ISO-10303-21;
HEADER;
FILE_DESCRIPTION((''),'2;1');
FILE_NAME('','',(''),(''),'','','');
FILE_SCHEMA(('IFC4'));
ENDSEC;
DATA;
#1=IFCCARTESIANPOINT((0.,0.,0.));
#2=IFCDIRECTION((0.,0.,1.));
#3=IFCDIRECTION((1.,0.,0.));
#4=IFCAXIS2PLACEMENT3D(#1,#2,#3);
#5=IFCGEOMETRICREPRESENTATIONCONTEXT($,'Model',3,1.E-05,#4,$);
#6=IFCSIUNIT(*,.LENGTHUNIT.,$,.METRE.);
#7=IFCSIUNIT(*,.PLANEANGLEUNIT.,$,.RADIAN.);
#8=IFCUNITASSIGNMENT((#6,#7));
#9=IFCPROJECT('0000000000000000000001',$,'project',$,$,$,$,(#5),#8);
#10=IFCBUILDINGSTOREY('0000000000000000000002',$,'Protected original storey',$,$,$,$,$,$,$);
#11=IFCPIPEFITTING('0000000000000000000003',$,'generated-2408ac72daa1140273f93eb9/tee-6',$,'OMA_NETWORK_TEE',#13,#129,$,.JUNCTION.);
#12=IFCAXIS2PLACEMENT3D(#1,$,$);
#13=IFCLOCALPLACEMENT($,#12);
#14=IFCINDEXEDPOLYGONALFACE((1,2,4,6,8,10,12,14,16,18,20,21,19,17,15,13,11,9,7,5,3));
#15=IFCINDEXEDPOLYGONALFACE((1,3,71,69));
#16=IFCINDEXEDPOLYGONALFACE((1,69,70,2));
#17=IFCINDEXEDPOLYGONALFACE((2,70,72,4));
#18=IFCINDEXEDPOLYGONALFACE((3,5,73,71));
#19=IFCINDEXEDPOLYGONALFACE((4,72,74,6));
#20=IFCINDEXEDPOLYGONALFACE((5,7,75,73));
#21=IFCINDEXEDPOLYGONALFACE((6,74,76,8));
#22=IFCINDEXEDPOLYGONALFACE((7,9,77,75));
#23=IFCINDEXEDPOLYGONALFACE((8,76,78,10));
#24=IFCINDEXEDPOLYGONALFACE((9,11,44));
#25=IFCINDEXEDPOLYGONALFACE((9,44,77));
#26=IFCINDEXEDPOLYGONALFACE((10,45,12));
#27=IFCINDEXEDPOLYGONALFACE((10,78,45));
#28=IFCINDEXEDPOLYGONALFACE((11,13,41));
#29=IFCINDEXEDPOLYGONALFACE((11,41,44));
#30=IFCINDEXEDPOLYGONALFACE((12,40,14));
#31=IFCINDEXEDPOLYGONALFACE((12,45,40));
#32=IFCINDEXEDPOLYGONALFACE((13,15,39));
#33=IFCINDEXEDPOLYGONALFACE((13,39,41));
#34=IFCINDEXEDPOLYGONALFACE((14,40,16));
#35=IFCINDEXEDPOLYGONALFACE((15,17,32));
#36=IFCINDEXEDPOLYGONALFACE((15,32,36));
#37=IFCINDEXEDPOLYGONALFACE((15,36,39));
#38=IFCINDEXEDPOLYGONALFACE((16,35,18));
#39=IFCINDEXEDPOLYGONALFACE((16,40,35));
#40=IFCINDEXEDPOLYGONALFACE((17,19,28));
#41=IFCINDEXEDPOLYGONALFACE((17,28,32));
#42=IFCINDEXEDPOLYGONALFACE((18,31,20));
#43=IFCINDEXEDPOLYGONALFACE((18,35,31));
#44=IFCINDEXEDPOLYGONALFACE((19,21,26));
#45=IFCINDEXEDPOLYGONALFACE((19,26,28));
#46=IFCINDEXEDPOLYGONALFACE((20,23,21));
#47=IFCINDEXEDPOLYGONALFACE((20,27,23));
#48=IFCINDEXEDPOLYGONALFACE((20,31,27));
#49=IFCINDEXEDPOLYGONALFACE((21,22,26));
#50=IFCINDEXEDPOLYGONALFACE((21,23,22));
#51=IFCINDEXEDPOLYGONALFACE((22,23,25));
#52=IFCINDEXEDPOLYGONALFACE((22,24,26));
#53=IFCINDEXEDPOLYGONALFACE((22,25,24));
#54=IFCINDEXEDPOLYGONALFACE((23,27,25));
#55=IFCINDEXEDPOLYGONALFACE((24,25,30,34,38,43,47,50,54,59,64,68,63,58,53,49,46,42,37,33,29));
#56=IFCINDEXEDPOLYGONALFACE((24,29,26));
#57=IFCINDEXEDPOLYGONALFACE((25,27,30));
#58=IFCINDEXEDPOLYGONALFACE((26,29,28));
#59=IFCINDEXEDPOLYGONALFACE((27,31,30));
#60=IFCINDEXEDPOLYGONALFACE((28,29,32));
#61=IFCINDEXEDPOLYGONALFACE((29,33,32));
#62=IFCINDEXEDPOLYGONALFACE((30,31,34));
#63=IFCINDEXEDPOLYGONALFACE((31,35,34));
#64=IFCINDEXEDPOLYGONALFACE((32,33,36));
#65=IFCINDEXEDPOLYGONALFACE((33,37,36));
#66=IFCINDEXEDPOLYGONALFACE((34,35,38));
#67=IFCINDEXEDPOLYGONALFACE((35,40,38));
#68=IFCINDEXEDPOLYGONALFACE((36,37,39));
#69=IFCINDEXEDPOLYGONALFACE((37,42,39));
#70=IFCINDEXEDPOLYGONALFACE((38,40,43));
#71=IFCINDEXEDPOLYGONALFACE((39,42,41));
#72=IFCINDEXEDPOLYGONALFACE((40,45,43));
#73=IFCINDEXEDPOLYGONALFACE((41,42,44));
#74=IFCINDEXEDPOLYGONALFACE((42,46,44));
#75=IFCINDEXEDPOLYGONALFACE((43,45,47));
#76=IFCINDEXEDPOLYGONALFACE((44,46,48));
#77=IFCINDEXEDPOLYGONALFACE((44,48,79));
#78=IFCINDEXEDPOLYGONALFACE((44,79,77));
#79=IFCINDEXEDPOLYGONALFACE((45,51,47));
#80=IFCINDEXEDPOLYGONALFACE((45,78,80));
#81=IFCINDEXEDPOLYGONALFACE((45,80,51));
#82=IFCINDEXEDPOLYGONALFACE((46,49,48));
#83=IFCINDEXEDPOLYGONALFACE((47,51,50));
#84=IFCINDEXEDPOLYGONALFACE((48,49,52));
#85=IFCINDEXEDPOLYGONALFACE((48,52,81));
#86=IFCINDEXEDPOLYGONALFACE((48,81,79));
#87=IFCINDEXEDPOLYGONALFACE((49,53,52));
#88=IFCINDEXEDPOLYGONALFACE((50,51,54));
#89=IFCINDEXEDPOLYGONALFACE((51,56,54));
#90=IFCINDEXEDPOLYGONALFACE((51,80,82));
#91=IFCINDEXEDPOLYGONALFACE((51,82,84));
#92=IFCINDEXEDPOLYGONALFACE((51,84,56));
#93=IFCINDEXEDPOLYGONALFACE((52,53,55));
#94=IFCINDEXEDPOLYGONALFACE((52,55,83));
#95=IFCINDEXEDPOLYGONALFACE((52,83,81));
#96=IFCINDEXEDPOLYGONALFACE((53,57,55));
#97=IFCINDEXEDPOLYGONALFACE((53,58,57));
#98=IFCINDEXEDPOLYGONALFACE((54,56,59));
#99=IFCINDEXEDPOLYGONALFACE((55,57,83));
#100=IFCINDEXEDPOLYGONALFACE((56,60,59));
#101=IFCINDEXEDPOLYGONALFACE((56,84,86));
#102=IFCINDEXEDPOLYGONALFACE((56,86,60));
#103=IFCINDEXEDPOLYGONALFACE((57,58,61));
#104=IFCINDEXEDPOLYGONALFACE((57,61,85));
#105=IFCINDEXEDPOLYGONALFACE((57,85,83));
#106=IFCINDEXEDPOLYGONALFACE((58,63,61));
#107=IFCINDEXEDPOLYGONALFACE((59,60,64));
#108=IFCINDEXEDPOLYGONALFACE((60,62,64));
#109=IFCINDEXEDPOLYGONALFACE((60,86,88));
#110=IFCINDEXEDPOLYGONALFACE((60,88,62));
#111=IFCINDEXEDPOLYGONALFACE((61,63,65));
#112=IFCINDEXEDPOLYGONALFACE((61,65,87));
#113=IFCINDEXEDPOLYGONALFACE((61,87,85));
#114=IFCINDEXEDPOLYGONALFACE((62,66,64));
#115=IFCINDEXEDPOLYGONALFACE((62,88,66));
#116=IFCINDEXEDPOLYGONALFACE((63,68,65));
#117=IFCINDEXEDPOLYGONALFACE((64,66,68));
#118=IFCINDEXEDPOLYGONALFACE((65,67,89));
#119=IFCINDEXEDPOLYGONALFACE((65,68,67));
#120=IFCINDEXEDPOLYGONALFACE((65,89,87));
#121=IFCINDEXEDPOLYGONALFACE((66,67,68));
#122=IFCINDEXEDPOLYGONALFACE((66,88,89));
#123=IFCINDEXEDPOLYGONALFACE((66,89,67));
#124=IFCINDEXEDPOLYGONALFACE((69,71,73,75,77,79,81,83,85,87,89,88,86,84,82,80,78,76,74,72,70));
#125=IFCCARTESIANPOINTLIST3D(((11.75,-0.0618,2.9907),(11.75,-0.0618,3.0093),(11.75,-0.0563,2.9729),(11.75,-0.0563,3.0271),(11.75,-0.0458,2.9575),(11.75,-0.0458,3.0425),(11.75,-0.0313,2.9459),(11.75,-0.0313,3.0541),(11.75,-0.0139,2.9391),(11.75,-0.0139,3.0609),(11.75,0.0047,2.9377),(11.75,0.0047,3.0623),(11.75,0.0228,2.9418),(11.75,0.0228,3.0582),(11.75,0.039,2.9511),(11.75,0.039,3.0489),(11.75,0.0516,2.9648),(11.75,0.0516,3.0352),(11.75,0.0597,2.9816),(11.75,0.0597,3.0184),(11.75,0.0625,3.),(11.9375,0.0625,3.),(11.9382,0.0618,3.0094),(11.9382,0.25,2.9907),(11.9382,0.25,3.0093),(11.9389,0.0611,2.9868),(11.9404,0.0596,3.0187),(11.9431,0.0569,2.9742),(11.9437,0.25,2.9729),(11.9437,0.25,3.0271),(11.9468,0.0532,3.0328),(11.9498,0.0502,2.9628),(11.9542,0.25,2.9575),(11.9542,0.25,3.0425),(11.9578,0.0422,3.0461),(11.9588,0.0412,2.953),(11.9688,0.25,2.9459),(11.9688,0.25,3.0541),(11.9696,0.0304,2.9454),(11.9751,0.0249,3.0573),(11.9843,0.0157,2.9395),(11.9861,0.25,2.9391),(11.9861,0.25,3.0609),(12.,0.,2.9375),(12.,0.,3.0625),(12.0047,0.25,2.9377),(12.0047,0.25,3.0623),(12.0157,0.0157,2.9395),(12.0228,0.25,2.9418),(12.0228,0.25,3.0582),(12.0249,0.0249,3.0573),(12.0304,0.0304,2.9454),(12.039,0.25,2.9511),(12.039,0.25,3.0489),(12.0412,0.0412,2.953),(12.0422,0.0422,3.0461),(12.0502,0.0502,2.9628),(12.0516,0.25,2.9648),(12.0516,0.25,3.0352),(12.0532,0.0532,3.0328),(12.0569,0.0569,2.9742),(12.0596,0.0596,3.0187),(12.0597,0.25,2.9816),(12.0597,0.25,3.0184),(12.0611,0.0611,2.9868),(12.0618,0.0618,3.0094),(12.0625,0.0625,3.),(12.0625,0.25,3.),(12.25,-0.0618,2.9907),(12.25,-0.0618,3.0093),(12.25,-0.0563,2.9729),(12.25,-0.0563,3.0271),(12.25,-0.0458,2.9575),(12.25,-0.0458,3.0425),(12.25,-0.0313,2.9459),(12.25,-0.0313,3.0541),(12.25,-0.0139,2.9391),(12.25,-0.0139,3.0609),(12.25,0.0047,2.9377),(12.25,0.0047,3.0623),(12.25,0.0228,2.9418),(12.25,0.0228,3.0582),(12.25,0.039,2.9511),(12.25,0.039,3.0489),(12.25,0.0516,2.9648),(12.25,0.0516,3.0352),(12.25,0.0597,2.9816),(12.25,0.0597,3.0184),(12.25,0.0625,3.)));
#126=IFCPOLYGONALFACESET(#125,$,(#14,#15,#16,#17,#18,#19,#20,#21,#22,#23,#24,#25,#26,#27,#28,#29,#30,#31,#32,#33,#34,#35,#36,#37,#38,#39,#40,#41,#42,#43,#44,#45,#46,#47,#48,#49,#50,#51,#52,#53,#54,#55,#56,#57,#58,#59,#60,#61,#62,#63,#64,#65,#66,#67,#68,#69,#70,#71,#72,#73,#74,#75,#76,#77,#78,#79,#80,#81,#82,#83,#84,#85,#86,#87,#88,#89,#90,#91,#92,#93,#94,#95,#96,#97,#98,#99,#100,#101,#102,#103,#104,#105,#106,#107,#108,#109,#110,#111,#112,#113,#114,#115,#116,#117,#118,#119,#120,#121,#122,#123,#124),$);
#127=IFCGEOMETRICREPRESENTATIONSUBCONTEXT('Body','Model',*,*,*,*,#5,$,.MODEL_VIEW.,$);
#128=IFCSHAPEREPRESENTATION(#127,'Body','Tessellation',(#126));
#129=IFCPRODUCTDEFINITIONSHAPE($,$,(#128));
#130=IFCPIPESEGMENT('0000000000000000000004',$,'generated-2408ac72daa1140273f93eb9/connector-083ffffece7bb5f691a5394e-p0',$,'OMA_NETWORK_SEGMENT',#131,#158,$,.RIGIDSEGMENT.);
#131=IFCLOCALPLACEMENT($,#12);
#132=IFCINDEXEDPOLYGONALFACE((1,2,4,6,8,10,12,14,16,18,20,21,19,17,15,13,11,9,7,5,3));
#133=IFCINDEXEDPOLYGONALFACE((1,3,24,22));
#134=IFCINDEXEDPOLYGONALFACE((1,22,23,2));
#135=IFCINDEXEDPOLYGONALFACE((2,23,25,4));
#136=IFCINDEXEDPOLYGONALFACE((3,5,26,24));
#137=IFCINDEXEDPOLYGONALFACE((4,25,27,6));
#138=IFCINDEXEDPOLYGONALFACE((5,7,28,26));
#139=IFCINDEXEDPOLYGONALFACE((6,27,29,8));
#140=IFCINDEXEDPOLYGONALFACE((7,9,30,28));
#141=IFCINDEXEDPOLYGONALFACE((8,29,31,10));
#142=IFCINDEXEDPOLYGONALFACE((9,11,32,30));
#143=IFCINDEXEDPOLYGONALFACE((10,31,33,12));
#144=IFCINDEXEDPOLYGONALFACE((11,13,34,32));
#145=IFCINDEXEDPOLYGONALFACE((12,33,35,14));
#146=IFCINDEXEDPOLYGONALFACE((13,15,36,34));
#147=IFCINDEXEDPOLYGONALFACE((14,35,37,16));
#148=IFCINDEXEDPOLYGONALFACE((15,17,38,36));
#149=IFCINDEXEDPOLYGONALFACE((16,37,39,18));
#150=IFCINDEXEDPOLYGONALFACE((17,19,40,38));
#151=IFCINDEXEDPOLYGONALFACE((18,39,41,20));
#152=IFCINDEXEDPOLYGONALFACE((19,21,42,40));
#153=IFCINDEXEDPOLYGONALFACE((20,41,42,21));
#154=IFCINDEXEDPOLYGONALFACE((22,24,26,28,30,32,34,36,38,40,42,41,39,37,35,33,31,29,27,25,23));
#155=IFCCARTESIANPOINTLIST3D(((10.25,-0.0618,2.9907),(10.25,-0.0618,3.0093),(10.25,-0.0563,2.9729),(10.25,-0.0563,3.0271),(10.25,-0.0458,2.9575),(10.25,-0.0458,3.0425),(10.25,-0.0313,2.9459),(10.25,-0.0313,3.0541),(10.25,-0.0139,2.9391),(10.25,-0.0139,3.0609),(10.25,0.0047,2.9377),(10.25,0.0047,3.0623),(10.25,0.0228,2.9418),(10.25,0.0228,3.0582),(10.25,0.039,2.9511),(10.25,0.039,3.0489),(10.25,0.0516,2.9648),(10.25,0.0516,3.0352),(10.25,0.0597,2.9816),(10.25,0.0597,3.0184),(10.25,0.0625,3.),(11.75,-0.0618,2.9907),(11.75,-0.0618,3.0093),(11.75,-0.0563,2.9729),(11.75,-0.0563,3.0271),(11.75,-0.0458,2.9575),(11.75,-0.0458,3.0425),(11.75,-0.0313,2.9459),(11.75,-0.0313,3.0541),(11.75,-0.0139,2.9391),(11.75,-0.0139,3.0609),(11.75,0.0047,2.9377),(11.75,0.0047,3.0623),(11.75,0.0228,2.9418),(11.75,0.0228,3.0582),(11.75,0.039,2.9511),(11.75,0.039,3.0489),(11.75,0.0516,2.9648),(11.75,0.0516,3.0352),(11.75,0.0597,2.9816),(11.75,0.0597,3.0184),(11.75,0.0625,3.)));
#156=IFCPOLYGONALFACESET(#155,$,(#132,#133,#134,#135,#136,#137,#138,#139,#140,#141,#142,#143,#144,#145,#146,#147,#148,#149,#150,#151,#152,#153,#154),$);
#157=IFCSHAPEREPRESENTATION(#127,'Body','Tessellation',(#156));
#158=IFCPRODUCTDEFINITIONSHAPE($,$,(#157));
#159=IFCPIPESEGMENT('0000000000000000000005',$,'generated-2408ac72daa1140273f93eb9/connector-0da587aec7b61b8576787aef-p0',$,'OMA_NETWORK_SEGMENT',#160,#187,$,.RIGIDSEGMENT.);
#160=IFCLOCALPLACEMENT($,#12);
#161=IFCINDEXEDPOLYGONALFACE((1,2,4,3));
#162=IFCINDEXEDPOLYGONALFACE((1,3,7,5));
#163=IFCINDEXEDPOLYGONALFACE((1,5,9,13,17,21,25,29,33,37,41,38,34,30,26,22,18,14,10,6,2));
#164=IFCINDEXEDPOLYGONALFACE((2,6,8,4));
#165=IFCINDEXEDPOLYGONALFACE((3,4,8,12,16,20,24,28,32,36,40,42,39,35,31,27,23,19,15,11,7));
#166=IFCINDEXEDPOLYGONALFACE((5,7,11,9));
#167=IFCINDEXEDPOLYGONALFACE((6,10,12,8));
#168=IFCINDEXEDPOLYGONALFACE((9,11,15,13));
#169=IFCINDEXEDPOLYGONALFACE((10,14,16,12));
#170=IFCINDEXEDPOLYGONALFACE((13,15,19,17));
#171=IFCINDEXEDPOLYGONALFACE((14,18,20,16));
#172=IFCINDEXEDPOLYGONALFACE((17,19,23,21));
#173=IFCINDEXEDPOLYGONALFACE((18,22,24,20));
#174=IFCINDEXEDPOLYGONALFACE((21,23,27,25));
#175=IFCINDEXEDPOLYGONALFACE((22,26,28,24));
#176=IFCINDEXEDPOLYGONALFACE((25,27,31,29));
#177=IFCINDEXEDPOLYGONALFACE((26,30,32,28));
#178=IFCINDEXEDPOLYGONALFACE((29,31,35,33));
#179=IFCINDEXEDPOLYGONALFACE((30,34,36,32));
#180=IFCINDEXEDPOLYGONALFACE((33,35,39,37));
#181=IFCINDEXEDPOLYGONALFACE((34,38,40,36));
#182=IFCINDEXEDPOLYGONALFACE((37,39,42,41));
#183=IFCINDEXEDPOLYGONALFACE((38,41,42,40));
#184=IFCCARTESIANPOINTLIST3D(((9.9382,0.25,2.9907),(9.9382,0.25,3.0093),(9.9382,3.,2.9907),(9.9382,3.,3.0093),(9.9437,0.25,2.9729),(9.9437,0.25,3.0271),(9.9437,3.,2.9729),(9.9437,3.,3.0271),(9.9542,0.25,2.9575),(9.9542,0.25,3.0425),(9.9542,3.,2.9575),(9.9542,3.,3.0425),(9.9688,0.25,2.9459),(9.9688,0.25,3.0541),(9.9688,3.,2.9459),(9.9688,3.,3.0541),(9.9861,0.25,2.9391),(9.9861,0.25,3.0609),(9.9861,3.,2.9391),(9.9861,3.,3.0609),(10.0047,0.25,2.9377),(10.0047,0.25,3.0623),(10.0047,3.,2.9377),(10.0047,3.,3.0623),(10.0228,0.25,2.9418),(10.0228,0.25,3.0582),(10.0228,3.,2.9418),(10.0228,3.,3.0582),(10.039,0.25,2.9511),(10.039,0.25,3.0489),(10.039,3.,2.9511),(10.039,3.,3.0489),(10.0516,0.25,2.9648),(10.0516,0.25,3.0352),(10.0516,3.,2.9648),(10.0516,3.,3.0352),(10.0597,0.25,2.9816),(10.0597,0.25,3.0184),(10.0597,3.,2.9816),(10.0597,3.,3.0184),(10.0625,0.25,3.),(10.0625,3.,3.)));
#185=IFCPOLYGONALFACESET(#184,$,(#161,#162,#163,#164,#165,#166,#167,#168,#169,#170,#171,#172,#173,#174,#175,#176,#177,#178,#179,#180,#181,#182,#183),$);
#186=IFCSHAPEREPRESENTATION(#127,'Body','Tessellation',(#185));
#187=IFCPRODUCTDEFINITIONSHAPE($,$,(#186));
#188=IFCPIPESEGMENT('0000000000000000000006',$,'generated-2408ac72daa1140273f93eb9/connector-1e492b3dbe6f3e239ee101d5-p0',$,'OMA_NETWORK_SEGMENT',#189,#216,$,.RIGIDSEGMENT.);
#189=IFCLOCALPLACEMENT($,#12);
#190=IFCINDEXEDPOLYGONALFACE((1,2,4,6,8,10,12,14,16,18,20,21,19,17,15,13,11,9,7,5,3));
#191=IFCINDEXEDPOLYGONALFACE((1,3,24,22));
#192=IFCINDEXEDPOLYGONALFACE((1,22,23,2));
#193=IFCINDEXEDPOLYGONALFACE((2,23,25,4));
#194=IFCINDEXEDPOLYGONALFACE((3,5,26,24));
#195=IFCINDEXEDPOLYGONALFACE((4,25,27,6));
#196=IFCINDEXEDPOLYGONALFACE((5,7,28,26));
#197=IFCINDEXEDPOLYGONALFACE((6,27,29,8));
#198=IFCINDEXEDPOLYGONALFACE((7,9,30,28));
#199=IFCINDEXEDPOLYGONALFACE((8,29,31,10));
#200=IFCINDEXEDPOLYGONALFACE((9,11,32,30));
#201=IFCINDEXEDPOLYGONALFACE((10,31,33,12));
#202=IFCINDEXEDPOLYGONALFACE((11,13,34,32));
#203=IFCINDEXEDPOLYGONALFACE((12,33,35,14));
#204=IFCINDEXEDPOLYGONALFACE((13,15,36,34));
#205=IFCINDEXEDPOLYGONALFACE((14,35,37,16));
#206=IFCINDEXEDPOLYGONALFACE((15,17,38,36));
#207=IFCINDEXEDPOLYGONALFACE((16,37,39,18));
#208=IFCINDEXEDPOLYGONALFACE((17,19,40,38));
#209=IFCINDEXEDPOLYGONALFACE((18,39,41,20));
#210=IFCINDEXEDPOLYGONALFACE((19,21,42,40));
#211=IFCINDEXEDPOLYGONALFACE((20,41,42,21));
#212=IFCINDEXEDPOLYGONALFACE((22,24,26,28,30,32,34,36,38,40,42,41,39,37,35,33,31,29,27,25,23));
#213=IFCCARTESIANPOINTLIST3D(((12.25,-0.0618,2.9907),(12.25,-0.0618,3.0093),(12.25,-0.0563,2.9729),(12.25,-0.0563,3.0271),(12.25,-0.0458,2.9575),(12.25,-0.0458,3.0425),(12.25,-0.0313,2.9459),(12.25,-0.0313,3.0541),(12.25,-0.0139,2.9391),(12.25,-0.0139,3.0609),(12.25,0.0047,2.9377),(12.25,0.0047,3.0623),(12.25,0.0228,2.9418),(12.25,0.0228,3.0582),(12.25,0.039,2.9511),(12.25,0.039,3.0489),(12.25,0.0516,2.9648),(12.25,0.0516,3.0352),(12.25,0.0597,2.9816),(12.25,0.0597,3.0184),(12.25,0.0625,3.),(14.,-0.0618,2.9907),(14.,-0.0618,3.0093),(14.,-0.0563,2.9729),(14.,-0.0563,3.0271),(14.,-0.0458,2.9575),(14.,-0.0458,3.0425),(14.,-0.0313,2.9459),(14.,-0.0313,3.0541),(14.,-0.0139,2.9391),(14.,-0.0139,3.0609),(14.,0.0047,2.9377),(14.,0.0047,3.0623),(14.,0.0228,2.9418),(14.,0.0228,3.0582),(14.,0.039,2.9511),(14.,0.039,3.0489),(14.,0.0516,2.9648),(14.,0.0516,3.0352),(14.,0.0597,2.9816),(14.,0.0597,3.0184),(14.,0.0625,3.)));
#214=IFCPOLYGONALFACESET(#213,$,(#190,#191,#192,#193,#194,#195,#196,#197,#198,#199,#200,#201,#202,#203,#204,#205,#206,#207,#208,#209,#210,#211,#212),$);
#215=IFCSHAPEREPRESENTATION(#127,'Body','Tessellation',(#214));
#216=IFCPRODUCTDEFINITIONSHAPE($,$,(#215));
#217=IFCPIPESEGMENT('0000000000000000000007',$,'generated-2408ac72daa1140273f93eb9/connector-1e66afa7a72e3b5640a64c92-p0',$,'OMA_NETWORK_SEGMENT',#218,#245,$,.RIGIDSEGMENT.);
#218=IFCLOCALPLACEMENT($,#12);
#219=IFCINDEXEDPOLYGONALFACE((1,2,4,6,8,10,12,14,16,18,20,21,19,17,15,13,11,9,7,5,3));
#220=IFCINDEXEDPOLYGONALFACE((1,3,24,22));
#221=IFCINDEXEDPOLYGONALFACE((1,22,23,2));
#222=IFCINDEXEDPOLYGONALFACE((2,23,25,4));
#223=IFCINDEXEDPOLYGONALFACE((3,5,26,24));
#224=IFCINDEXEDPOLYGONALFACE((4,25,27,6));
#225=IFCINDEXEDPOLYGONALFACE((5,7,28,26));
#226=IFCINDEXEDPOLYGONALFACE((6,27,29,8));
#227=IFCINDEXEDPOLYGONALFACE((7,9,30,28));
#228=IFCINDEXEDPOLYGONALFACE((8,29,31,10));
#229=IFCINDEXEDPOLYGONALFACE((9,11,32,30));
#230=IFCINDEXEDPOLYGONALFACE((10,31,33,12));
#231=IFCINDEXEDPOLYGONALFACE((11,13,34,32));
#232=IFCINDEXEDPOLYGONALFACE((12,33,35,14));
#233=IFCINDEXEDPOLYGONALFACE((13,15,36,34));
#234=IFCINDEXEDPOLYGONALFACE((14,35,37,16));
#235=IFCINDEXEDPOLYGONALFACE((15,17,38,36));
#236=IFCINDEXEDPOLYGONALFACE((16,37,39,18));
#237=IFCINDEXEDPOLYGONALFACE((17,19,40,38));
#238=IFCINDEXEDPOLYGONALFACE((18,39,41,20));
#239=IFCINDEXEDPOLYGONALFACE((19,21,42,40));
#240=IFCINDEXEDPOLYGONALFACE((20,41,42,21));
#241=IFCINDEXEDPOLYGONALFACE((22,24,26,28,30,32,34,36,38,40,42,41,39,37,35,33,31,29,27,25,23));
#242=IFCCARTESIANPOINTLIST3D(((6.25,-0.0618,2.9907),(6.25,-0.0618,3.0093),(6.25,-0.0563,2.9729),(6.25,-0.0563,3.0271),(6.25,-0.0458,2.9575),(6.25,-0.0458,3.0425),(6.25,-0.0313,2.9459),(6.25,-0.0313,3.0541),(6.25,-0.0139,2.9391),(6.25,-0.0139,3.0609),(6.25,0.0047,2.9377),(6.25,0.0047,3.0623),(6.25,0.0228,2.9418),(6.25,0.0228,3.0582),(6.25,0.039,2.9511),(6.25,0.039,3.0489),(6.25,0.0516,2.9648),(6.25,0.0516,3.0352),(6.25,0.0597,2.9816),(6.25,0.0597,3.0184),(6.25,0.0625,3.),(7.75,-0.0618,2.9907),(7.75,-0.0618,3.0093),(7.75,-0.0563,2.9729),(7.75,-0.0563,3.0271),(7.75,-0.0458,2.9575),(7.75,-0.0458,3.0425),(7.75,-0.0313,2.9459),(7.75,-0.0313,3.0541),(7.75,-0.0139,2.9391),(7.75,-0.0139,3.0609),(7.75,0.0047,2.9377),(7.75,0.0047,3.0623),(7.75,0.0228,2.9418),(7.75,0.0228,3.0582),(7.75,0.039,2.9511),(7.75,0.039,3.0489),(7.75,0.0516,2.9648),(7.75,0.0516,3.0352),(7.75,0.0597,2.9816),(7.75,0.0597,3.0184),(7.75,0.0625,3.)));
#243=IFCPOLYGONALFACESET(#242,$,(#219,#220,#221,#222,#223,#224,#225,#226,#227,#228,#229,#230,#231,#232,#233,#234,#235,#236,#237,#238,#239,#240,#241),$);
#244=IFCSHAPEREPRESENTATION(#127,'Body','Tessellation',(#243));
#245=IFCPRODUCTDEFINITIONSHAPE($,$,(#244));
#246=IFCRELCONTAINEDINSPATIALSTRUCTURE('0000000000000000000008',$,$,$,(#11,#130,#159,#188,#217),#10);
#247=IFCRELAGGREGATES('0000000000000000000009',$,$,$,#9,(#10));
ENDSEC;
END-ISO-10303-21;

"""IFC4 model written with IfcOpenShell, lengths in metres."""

from ifc_helpers import new_model, si_unit, frame, origin_with_axes, origin_2d, place, context, subcontext, project, spatial, circle, extrude, boolean, element, save


model = new_model("IFC4")

# Units and contexts
model_context = context("Model", 3, precision=1e-05, world=origin_with_axes())
body_context = subcontext(model_context, "Body", "Model", "MODEL_VIEW")
ifc_project = project(units=[si_unit("LENGTHUNIT", "METRE"), si_unit("PLANEANGLEUNIT", "RADIAN")], contexts=[model_context])

# Storey
storey = spatial("IfcBuildingStorey", under=ifc_project, Name="Protected original storey")

# Pipe fitting
pipe_fitting_1_placement = place(None, origin_with_axes())
element("IfcPipeFitting", 1, at=pipe_fitting_1_placement, inside=storey, Name="generated-2408ac72daa1140273f93eb9/tee-6", ObjectType="OMA_NETWORK_TEE", PredefinedType="JUNCTION", context=body_context, shape_type="CSG", body=[
    boolean("UNION", extrude(circle(Radius=0.0625, at=origin_2d()), frame((11.75, 0.0, 3.0), z_axis=(1.0, 0.0, 0.0), x_axis=(0.0, 1.0, 0.0)), (0.0, 0.0, 1.0), 0.5), extrude(circle(Radius=0.0625, at=origin_2d()), frame((12.0, 0.0, 3.0), z_axis=(0.0, 1.0, 0.0), x_axis=(1.0, 0.0, 0.0)), (0.0, 0.0, 1.0), 0.25)),
])

# Pipe segments
pipe_segment_1_placement = place(None, origin_with_axes())
element("IfcPipeSegment", 2, at=pipe_segment_1_placement, inside=storey, Name="generated-2408ac72daa1140273f93eb9/connector-083ffffece7bb5f691a5394e-p0", ObjectType="OMA_NETWORK_SEGMENT", PredefinedType="RIGIDSEGMENT", context=body_context, shape_type="SweptSolid", body=[
    extrude(circle(Radius=0.0625, at=origin_2d()), frame((10.25, 0.0, 3.0), z_axis=(1.0, 0.0, 0.0), x_axis=(0.0, 1.0, 0.0)), (0.0, 0.0, 1.0), 1.5),
])
pipe_segment_2_placement = place(None, origin_with_axes())
element("IfcPipeSegment", 3, at=pipe_segment_2_placement, inside=storey, Name="generated-2408ac72daa1140273f93eb9/connector-0da587aec7b61b8576787aef-p0", ObjectType="OMA_NETWORK_SEGMENT", PredefinedType="RIGIDSEGMENT", context=body_context, shape_type="SweptSolid", body=[
    extrude(circle(Radius=0.0625, at=origin_2d()), frame((10.0, 0.25, 3.0), z_axis=(0.0, 1.0, 0.0), x_axis=(1.0, 0.0, 0.0)), (0.0, 0.0, 1.0), 2.75),
])
pipe_segment_3_placement = place(None, origin_with_axes())
element("IfcPipeSegment", 4, at=pipe_segment_3_placement, inside=storey, Name="generated-2408ac72daa1140273f93eb9/connector-1e492b3dbe6f3e239ee101d5-p0", ObjectType="OMA_NETWORK_SEGMENT", PredefinedType="RIGIDSEGMENT", context=body_context, shape_type="SweptSolid", body=[
    extrude(circle(Radius=0.0625, at=origin_2d()), frame((12.25, 0.0, 3.0), z_axis=(1.0, 0.0, 0.0), x_axis=(0.0, 1.0, 0.0)), (0.0, 0.0, 1.0), 1.75),
])
pipe_segment_4_placement = place(None, origin_with_axes())
element("IfcPipeSegment", 5, at=pipe_segment_4_placement, inside=storey, Name="generated-2408ac72daa1140273f93eb9/connector-1e66afa7a72e3b5640a64c92-p0", ObjectType="OMA_NETWORK_SEGMENT", PredefinedType="RIGIDSEGMENT", context=body_context, shape_type="SweptSolid", body=[
    extrude(circle(Radius=0.0625, at=origin_2d()), frame((6.25, 0.0, 3.0), z_axis=(1.0, 0.0, 0.0), x_axis=(0.0, 1.0, 0.0)), (0.0, 0.0, 1.0), 1.5),
])

save(model, "model.ifc")
